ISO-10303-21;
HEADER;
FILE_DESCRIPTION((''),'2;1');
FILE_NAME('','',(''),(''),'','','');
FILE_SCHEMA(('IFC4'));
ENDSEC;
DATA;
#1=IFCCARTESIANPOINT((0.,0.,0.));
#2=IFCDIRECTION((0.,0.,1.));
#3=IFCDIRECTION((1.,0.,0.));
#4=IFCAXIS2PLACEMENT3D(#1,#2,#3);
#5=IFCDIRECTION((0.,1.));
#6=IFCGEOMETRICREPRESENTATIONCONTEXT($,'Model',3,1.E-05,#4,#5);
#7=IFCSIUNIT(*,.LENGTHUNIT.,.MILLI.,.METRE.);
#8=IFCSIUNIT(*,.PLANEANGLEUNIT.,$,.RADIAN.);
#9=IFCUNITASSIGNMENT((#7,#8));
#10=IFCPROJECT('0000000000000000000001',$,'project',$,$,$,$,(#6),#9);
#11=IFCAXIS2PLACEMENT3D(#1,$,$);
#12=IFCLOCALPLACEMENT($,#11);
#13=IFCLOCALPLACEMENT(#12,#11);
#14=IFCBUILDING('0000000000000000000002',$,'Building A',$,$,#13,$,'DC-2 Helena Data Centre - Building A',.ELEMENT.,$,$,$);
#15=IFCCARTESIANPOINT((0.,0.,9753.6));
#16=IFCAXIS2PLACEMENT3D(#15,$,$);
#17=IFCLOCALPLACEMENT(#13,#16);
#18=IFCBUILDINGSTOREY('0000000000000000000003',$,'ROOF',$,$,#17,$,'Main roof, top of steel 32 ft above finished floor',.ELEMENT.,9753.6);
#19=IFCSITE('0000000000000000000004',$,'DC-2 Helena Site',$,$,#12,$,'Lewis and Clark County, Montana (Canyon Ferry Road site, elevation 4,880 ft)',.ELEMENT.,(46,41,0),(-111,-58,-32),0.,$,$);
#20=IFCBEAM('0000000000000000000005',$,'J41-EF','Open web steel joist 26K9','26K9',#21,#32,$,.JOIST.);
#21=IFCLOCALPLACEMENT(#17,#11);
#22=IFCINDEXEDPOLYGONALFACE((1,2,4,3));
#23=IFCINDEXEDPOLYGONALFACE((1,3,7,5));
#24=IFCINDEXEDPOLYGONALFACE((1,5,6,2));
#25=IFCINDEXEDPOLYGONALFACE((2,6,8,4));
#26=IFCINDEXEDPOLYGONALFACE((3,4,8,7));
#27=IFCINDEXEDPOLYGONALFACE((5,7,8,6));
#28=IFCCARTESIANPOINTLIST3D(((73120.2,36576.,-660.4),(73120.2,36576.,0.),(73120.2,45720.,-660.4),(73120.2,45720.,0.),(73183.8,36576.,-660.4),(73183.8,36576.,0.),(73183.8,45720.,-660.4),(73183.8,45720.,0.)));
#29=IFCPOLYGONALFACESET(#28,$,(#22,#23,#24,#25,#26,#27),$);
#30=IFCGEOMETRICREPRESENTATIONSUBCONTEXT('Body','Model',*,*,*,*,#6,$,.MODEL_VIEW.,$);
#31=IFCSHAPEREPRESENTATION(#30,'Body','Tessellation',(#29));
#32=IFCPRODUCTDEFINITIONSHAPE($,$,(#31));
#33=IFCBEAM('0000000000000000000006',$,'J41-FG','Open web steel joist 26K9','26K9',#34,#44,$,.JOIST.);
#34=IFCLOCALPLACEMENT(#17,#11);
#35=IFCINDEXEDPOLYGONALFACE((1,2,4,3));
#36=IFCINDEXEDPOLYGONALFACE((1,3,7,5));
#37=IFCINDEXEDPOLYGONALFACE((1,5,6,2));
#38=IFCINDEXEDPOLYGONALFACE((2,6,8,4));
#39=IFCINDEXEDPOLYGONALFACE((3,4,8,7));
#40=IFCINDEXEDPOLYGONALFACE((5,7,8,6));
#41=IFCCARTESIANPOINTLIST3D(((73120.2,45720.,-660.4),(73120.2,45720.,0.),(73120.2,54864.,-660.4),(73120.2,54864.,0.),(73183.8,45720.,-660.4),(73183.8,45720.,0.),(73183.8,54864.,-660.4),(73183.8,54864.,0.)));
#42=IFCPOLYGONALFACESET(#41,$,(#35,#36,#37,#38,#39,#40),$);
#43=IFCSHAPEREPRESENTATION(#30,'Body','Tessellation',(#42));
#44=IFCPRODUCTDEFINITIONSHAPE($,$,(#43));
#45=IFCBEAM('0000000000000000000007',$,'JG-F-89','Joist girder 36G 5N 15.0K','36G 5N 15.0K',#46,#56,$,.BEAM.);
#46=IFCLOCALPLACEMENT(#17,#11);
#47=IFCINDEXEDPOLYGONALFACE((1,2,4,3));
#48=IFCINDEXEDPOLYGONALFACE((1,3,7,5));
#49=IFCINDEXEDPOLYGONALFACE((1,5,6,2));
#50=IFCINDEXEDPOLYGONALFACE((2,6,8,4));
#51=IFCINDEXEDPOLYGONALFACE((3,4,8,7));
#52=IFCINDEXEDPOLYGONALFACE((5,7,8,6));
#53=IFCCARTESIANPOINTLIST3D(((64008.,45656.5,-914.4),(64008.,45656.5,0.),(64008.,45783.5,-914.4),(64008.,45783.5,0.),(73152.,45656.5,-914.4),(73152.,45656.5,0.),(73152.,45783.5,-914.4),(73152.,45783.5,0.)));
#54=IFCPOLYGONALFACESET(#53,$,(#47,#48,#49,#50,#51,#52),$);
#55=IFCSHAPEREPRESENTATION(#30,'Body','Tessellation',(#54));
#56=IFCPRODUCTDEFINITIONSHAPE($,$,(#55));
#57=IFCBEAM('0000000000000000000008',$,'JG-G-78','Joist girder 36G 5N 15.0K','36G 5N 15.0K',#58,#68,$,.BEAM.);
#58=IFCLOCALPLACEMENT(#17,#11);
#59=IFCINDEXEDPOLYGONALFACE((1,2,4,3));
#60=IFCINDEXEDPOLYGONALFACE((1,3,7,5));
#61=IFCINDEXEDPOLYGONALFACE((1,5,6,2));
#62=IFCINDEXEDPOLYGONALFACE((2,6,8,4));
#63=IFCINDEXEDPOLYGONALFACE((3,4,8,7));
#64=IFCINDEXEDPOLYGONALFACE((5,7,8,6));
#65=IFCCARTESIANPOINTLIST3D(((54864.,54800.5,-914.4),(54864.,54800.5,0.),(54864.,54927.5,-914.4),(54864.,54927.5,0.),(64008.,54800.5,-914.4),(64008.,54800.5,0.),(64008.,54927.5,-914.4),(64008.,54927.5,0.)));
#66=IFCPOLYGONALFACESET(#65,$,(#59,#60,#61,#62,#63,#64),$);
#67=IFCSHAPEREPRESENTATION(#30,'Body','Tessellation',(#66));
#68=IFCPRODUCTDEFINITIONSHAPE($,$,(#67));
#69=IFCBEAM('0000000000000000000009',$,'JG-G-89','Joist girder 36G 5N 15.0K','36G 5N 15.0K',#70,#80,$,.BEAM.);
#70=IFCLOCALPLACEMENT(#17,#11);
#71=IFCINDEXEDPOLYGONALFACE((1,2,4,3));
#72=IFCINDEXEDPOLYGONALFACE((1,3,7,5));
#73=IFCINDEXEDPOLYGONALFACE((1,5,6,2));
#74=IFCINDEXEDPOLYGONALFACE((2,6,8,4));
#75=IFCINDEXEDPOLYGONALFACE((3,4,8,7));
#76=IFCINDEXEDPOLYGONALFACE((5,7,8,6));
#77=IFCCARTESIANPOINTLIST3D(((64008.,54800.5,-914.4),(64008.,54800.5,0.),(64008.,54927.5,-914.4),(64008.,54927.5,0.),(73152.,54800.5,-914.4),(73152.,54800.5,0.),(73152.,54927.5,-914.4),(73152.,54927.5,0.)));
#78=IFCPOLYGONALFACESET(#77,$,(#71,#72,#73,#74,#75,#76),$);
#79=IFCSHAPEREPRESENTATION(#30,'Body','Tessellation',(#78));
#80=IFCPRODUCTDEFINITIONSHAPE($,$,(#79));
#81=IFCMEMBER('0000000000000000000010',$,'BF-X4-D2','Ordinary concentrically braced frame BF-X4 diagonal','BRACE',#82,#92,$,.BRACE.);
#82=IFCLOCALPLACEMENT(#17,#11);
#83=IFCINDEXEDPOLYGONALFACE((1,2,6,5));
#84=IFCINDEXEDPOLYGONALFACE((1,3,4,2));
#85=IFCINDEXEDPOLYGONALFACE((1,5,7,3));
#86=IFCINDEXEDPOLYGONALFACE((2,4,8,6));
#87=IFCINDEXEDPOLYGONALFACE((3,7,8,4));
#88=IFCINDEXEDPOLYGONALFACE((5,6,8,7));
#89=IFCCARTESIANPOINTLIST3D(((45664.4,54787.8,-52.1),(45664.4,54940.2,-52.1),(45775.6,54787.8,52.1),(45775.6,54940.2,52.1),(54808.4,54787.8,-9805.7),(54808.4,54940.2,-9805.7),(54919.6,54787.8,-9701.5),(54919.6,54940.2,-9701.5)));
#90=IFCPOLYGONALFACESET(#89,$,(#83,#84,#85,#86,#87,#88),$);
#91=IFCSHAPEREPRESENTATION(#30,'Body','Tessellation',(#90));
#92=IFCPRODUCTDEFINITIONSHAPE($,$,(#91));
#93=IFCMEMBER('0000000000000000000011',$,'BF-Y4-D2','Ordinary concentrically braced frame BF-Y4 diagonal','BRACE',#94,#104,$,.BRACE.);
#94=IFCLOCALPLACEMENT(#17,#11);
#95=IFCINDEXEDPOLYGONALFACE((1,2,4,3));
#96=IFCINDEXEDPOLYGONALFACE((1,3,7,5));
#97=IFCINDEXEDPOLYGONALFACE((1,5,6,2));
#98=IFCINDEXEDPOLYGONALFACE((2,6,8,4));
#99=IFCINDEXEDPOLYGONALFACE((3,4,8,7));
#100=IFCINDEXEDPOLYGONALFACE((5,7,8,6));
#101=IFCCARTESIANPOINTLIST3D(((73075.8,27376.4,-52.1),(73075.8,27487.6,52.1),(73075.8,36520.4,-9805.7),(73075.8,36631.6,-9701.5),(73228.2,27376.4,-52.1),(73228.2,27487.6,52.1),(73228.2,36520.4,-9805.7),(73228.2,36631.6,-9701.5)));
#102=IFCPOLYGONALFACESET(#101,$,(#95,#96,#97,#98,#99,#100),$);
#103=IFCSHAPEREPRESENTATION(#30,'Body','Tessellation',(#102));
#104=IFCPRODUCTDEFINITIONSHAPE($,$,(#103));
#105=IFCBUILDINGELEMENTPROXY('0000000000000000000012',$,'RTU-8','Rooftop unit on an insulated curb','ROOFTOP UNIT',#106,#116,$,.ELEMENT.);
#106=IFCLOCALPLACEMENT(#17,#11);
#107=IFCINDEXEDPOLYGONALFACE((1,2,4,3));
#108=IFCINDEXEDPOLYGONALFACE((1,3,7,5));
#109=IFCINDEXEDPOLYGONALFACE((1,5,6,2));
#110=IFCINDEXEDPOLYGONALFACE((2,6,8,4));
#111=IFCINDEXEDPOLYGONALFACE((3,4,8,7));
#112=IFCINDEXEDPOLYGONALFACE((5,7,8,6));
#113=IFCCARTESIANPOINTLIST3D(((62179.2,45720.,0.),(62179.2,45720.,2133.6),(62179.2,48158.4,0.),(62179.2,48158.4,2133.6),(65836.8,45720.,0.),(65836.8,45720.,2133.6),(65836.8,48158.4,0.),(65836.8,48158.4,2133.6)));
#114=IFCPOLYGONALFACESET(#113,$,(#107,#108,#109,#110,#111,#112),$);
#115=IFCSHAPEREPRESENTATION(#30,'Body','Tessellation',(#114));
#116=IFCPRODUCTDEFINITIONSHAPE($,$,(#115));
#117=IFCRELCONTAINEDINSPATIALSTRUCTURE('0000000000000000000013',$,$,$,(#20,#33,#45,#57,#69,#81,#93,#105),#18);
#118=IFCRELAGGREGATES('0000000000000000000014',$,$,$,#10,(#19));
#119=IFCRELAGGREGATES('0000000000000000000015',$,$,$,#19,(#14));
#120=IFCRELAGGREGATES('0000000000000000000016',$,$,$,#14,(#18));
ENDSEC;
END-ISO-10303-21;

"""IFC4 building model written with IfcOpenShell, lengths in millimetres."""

from ifc_helpers import new_model, si_unit, direction, frame, origin, origin_with_axes, origin_2d, place, context, subcontext, project, spatial, rectangle, extrude, element, save


model = new_model("IFC4")

# Units and contexts
model_context = context("Model", 3, precision=1e-05, world=origin_with_axes(), true_north=direction((0.0, 1.0)))
body_context = subcontext(model_context, "Body", "Model", "MODEL_VIEW")
ifc_project = project(units=[si_unit("LENGTHUNIT", "METRE", prefix="MILLI"), si_unit("PLANEANGLEUNIT", "RADIAN")], contexts=[model_context])

# Site, building, storey
site_placement = place(None, origin())
site = spatial("IfcSite", under=ifc_project, at=site_placement, Name="DC-2 Helena Site", LongName="Lewis and Clark County, Montana (Canyon Ferry Road site, elevation 4,880 ft)", CompositionType="ELEMENT", RefLatitude=(46, 41, 0), RefLongitude=(-111, -58, -32), RefElevation=0.0)
building_placement = place(site_placement, origin())
building = spatial("IfcBuilding", under=site, at=building_placement, Name="Building A", LongName="DC-2 Helena Data Centre - Building A", CompositionType="ELEMENT")
storey_placement = place(building_placement, frame((0.0, 0.0, 9753.6)))
storey = spatial("IfcBuildingStorey", under=building, at=storey_placement, Name="ROOF", LongName="Main roof, top of steel 32 ft above finished floor", CompositionType="ELEMENT", Elevation=9753.6)

# Shared definitions
placement_1 = place(storey_placement, frame((54864.0, 54864.0, -9753.6)))
placement_2 = place(storey_placement, frame((73152.0, 36576.0, -9753.6)))

# Beams
placement_3 = place(storey_placement, frame((64008.0, 45720.0, 0.0)))
for number, where, name in (
    (1, (73152.0, 36576.0, 0.0), "J41-EF"),
    (2, (73152.0, 45720.0, 0.0), "J41-FG"),
):
    element("IfcBeam", number, at=place(storey_placement, frame(where)), inside=storey, Name=name, Description="Open web steel joist 26K9", ObjectType="26K9", PredefinedType="JOIST", context=body_context, shape_type="SweptSolid", body=[
        extrude(rectangle(XDim=63.5, YDim=660.4, at=origin_2d()), frame((0.0, 0.0, -330.2), z_axis=(0.0, 1.0, 0.0), x_axis=(1.0, 0.0, 0.0)), (0.0, 0.0, 1.0), 9144.0),
    ])
element("IfcBeam", 3, at=placement_3, inside=storey, Name="JG-F-89", Description="Joist girder 36G 5N 15.0K", ObjectType="36G 5N 15.0K", PredefinedType="BEAM", context=body_context, shape_type="SweptSolid", body=[
    extrude(rectangle(XDim=127.0, YDim=914.4, at=origin_2d()), frame((0.0, 0.0, -457.2), z_axis=(1.0, 0.0, 0.0), x_axis=(0.0, 1.0, 0.0)), (0.0, 0.0, 1.0), 9144.0),
])
for number, where, name in (
    (4, (54864.0, 54864.0, 0.0), "JG-G-78"),
    (5, (64008.0, 54864.0, 0.0), "JG-G-89"),
):
    element("IfcBeam", number, at=place(storey_placement, frame(where)), inside=storey, Name=name, Description="Joist girder 36G 5N 15.0K", ObjectType="36G 5N 15.0K", PredefinedType="BEAM", context=body_context, shape_type="SweptSolid", body=[
        extrude(rectangle(XDim=127.0, YDim=914.4, at=origin_2d()), frame((0.0, 0.0, -457.2), z_axis=(1.0, 0.0, 0.0), x_axis=(0.0, 1.0, 0.0)), (0.0, 0.0, 1.0), 9144.0),
    ])

# Members
element("IfcMember", 6, at=placement_1, inside=storey, Name="BF-X4-D2", Description="Ordinary concentrically braced frame BF-X4 diagonal", ObjectType="BRACE", PredefinedType="BRACE", context=body_context, shape_type="SweptSolid", body=[
    extrude(rectangle(XDim=152.4, YDim=152.4, at=origin_2d()), frame((0.0, 0.0, 0.0), z_axis=(-0.683941, 0.0, 0.729537), x_axis=(0.0, 1.0, 0.0)), (0.0, 0.0, 1.0), 13369.6),
])
element("IfcMember", 7, at=placement_2, inside=storey, Name="BF-Y4-D2", Description="Ordinary concentrically braced frame BF-Y4 diagonal", ObjectType="BRACE", PredefinedType="BRACE", context=body_context, shape_type="SweptSolid", body=[
    extrude(rectangle(XDim=152.4, YDim=152.4, at=origin_2d()), frame((0.0, 0.0, 0.0), z_axis=(0.0, -0.683941, 0.729537), x_axis=(1.0, 0.0, 0.0)), (0.0, 0.0, 1.0), 13369.6),
])

# Building element proxy
proxy_placement = place(storey_placement, frame((64008.0, 46939.2, 0.0)))
element("IfcBuildingElementProxy", 8, at=proxy_placement, inside=storey, Name="RTU-8", Description="Rooftop unit on an insulated curb", ObjectType="ROOFTOP UNIT", PredefinedType="ELEMENT", context=body_context, shape_type="SweptSolid", body=[
    extrude(rectangle(XDim=3657.6, YDim=2438.4, at=origin_2d()), origin(), (0.0, 0.0, 1.0), 2133.6),
])

save(model, "model.ifc")
